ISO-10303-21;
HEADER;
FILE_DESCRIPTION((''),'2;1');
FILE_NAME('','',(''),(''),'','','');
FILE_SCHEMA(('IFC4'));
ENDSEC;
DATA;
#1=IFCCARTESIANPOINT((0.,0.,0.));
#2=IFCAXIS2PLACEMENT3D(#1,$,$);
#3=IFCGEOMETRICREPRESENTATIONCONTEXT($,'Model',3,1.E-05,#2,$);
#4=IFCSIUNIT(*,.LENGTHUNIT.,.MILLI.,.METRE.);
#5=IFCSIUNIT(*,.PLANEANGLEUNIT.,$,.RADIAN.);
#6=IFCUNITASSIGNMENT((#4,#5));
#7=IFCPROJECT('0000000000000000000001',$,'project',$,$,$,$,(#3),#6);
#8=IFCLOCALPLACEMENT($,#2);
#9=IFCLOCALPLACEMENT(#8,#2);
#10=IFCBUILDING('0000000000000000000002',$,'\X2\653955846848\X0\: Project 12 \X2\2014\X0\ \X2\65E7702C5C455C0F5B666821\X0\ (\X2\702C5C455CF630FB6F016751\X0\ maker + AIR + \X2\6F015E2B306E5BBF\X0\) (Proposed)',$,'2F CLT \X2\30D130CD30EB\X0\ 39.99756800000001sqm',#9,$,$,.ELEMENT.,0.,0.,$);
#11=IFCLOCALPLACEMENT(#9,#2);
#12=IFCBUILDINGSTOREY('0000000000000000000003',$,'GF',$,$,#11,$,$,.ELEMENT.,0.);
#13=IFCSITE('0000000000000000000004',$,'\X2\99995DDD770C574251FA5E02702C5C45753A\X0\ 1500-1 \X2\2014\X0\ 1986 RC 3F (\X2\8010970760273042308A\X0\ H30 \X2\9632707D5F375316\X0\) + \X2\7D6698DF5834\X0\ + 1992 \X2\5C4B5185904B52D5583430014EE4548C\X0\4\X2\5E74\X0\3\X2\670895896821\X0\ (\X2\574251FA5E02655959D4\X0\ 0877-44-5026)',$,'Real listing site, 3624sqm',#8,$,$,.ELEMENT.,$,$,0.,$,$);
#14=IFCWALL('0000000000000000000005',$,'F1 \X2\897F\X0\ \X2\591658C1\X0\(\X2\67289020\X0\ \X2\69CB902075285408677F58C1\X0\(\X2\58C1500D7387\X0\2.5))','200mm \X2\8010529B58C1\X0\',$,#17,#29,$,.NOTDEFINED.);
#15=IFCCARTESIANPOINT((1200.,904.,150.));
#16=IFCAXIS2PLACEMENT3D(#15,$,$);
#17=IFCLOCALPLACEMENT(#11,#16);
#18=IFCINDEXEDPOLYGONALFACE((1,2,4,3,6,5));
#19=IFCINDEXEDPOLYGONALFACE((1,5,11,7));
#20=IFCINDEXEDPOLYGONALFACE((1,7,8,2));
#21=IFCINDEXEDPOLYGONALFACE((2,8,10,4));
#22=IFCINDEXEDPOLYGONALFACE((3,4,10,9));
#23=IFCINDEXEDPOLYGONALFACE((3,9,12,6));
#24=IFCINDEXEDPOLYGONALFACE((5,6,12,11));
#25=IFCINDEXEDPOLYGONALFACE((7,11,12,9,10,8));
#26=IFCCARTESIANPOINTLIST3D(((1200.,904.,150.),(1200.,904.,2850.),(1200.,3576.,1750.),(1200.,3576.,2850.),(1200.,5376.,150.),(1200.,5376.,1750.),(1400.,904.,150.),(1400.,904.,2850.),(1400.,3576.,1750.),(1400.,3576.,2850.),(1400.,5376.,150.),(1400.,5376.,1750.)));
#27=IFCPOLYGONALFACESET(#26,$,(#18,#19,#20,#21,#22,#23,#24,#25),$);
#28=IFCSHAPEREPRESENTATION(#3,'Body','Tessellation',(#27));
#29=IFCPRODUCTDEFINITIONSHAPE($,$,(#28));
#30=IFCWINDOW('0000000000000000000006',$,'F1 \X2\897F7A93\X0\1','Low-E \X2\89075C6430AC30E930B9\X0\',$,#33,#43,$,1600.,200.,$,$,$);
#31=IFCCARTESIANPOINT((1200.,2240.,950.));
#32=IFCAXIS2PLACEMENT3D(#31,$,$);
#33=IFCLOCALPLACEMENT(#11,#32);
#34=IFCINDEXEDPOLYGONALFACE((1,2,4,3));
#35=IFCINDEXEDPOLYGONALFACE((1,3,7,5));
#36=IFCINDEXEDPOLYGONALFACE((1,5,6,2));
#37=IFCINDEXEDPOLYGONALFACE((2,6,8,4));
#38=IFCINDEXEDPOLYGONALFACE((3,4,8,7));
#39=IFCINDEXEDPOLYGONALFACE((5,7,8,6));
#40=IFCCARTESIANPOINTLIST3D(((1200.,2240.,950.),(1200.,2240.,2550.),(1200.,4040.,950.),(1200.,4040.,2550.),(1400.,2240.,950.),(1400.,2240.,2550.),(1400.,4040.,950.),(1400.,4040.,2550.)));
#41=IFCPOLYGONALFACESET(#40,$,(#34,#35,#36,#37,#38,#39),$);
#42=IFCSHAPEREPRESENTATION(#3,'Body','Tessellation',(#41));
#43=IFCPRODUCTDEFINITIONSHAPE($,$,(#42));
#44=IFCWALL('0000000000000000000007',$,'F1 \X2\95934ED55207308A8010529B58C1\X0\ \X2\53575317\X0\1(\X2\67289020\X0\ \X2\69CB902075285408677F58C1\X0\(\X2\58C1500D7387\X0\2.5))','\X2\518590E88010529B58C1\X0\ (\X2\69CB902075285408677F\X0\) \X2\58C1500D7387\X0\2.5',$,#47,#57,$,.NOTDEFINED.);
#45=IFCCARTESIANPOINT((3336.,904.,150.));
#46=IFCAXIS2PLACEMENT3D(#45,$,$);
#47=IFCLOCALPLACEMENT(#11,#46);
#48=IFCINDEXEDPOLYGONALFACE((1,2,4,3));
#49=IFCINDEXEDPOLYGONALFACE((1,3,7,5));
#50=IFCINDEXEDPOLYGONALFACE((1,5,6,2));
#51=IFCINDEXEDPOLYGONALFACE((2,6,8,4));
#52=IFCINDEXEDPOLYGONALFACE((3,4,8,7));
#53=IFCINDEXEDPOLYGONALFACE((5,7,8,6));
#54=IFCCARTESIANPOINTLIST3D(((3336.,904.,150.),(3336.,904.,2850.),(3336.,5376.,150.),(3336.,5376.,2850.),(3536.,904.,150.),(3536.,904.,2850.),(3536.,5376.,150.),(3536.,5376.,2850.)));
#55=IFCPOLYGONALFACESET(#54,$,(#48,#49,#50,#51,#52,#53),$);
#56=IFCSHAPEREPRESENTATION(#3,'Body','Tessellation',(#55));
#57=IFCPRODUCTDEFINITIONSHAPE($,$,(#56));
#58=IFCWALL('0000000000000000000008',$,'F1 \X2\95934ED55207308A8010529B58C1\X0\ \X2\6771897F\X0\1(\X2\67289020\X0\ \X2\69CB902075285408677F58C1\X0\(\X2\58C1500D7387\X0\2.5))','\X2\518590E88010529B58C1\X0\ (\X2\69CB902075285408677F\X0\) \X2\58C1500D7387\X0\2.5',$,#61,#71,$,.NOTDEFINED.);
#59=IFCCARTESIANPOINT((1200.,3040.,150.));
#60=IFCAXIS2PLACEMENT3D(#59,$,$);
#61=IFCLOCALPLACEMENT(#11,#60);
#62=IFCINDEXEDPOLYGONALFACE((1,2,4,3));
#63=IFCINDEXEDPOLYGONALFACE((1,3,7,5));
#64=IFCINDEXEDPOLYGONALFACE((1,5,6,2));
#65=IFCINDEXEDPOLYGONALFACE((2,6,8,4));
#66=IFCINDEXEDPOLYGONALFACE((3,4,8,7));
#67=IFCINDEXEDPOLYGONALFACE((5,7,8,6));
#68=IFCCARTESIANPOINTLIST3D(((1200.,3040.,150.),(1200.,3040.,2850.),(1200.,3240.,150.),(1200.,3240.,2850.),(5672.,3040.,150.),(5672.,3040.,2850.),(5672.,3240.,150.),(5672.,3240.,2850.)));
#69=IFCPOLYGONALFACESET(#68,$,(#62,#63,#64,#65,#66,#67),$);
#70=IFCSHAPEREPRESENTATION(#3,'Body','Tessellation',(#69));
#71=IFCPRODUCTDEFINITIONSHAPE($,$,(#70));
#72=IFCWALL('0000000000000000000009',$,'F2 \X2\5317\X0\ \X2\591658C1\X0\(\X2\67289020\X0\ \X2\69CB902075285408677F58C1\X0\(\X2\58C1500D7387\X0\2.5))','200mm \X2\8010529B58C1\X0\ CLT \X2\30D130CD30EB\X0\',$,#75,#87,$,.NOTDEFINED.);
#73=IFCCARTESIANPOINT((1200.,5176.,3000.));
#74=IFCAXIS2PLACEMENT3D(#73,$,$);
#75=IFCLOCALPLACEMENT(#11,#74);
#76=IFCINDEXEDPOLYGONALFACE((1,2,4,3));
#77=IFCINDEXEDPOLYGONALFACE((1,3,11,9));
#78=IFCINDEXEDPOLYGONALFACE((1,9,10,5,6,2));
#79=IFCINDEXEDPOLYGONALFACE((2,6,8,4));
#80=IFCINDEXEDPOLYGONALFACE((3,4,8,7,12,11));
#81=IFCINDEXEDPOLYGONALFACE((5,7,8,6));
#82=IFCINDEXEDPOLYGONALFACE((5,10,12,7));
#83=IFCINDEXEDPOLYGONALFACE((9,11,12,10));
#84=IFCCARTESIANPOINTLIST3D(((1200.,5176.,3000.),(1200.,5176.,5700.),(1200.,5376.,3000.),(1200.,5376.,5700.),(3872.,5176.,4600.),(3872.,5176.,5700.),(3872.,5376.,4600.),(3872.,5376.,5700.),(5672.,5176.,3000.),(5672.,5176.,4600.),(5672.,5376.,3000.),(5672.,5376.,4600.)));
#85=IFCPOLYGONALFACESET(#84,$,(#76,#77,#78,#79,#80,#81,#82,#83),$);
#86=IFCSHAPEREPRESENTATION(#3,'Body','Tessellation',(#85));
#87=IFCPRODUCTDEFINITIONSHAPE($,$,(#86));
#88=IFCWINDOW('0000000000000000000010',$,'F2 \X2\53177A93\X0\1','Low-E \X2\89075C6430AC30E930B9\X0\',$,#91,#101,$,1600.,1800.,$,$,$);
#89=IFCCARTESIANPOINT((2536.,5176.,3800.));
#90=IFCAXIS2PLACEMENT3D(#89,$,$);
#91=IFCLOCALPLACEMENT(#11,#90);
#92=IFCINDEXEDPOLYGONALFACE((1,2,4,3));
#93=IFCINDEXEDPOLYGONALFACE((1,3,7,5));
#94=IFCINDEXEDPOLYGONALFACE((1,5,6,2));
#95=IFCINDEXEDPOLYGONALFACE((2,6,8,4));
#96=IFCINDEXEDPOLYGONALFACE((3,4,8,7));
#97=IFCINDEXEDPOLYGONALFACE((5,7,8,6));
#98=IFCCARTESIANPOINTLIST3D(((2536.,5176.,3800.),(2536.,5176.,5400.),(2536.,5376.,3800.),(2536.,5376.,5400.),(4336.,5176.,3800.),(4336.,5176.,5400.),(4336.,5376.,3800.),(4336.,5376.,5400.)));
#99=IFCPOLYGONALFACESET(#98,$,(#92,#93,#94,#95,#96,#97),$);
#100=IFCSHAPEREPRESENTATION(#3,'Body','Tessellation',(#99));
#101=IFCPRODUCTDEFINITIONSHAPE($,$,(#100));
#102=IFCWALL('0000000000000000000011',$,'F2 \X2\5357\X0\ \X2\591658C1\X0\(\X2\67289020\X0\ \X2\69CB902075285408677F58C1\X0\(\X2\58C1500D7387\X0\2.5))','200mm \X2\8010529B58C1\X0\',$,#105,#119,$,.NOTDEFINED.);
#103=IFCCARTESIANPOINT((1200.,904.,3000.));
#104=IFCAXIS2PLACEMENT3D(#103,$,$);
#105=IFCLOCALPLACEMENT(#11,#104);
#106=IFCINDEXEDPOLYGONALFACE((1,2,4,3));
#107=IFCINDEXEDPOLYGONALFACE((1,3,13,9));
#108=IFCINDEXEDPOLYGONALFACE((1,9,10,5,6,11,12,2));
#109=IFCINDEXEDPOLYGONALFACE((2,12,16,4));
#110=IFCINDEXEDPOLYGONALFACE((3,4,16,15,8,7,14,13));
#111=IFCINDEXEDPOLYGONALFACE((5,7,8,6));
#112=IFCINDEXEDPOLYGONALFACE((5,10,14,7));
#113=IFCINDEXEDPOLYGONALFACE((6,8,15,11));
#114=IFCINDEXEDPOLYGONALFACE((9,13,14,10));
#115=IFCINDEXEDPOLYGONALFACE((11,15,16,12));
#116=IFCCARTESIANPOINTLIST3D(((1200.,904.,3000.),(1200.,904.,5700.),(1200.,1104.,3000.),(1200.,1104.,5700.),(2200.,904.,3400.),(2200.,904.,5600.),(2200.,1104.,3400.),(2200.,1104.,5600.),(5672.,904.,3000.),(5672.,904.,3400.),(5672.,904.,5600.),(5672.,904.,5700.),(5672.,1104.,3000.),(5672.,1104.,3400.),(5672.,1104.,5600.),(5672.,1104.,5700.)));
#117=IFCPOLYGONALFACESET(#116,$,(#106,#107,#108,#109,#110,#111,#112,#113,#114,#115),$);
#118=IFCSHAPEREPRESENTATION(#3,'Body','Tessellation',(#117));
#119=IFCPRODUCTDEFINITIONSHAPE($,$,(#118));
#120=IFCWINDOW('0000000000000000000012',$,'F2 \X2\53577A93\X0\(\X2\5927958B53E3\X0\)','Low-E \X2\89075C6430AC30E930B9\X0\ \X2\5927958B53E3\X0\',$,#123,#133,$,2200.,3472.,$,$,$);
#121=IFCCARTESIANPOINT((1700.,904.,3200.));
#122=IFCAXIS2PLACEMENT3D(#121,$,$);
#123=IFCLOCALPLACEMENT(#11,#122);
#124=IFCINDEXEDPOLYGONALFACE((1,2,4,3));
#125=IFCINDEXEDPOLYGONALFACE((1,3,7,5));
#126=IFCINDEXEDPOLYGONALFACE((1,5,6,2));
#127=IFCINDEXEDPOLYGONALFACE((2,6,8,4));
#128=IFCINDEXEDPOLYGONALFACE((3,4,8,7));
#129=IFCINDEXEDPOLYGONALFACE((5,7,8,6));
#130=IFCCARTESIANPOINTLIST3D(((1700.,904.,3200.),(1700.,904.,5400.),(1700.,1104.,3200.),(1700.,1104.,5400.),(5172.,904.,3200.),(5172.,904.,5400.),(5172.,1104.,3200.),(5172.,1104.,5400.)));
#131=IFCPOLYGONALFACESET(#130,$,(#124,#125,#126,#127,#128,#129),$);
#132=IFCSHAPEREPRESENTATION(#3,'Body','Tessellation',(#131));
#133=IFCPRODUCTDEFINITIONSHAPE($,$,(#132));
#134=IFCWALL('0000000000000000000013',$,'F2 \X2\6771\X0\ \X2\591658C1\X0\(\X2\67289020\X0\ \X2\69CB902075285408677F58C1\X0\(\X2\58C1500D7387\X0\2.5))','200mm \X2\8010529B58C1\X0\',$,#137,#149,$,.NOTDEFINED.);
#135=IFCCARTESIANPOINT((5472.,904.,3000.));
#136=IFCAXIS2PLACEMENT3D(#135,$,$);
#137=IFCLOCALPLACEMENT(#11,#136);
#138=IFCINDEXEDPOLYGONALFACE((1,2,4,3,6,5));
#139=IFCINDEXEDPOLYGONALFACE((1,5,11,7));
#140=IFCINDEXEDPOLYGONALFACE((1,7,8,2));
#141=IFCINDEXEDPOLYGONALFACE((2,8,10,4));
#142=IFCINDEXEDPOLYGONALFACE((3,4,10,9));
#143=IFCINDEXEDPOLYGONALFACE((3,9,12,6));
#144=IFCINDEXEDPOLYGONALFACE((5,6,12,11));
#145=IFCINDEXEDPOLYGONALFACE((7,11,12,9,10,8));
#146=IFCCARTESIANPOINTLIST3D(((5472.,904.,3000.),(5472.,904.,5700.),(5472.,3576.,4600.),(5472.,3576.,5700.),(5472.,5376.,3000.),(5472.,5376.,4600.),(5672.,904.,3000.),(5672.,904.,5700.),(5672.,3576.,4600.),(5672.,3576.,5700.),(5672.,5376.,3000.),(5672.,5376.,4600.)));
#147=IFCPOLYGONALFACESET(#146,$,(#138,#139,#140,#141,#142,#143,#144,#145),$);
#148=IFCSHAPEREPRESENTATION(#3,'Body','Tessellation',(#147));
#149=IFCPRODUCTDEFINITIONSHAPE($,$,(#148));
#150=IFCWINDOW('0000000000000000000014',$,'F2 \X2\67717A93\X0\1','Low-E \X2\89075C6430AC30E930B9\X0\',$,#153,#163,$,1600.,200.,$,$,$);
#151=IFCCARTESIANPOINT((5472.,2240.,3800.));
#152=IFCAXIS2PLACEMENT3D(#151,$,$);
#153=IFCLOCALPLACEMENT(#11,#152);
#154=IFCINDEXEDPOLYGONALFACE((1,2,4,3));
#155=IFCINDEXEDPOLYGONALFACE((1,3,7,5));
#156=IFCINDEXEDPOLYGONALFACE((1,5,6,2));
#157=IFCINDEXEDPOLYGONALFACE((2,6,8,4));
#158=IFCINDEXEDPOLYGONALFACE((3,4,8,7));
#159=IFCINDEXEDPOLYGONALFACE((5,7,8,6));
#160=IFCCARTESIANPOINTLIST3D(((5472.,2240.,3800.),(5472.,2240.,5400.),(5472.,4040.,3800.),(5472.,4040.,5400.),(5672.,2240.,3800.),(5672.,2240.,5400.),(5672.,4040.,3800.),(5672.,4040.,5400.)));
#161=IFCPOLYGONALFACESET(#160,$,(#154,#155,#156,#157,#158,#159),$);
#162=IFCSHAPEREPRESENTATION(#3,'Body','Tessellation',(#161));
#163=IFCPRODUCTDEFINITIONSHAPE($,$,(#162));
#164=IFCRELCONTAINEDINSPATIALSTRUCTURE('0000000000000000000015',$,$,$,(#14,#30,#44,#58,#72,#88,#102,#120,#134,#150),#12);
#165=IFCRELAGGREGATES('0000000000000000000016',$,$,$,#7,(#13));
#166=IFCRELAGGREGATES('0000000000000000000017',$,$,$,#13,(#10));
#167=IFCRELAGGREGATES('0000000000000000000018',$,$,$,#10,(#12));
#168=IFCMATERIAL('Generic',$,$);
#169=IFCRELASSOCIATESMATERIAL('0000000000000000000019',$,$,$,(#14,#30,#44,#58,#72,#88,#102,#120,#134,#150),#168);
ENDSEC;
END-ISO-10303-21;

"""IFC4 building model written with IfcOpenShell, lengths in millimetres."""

from ifc_helpers import new_model, si_unit, frame, frame_2d, origin, place, context, project, spatial, rectangle, extrude, material, element, fill, save


model = new_model("IFC4")

# Units and contexts
model_context = context("Model", 3, precision=1e-05, world=origin())
ifc_project = project(units=[si_unit("LENGTHUNIT", "METRE", prefix="MILLI"), si_unit("PLANEANGLEUNIT", "RADIAN")], contexts=[model_context])

# Site, building, storey
site_placement = place(None, origin())
site = spatial("IfcSite", under=ifc_project, at=site_placement, Name="香川県坂出市瀬居町 1500-1 — 1986 RC 3F (耐震性あり H30 防災強化) + 給食場 + 1992 屋内運動場、令和4年3月閉校 (坂出市教委 0877-44-5026)", ObjectType="Real listing site, 3624sqm", CompositionType="ELEMENT", RefElevation=0.0)
building_placement = place(site_placement, origin())
building = spatial("IfcBuilding", under=site, at=building_placement, Name="改善案: Project 12 — 旧瀬居小学校 (瀬居島・漁村 maker + AIR + 漁師の宿) (Proposed)", ObjectType="2F CLT パネル 39.99756800000001sqm", CompositionType="ELEMENT", ElevationOfRefHeight=0.0, ElevationOfTerrain=0.0)
storey_placement = place(building_placement, origin())
storey = spatial("IfcBuildingStorey", under=building, at=storey_placement, Name="GF", CompositionType="ELEMENT", Elevation=0.0)

# Shared definitions
ifc_material_1 = material(Name="Generic")

# Wall, opening, window
wall_1_placement = place(storey_placement, frame((1200.0, 904.0, 150.0)))
wall_1 = element("IfcWall", 1, at=wall_1_placement, inside=storey, material=ifc_material_1, Name="F1 西 外壁(木造 構造用合板壁(壁倍率2.5))", Description="200mm 耐力壁", PredefinedType="NOTDEFINED", context=model_context, shape_type="SweptSolid", body=[
    extrude(rectangle(XDim=200.0, YDim=4472.0, at=frame_2d((100.0, 2236.0))), frame((1200.0, 904.0, 150.0)), (0.0, 0.0, 1.0), 2700.0),
])
opening_1_placement = place(storey_placement, frame((1200.0, 2240.0, 950.0)))
opening_1 = element("IfcOpeningElement", 2, at=opening_1_placement, cuts=wall_1, PredefinedType="NOTDEFINED", context=model_context, shape_type="SweptSolid", body=[
    extrude(rectangle(XDim=200.0, YDim=1800.0, at=frame_2d((100.0, 900.0))), frame((1200.0, 2240.0, 950.0)), (0.0, 0.0, 1.0), 1600.0),
])
window_1_placement = place(storey_placement, frame((1200.0, 2240.0, 950.0)))
window_1 = element("IfcWindow", 3, at=window_1_placement, inside=storey, material=ifc_material_1, Name="F1 西窓1", Description="Low-E 複層ガラス", OverallHeight=1600.0, OverallWidth=200.0, context=model_context, shape_type="SweptSolid", body=[
    extrude(rectangle(XDim=200.0, YDim=1800.0, at=frame_2d((100.0, 900.0))), frame((1200.0, 2240.0, 950.0)), (0.0, 0.0, 1.0), 1600.0),
])
fill(opening_1, window_1)

# Walls
wall_2_placement = place(storey_placement, frame((3336.0, 904.0, 150.0)))
element("IfcWall", 4, at=wall_2_placement, inside=storey, material=ifc_material_1, Name="F1 間仕切り耐力壁 南北1(木造 構造用合板壁(壁倍率2.5))", Description="内部耐力壁 (構造用合板) 壁倍率2.5", PredefinedType="NOTDEFINED", context=model_context, shape_type="SweptSolid", body=[
    extrude(rectangle(XDim=200.0, YDim=4472.0, at=frame_2d((100.0, 2236.0))), frame((3336.0, 904.0, 150.0)), (0.0, 0.0, 1.0), 2700.0),
])
wall_3_placement = place(storey_placement, frame((1200.0, 3040.0, 150.0)))
element("IfcWall", 5, at=wall_3_placement, inside=storey, material=ifc_material_1, Name="F1 間仕切り耐力壁 東西1(木造 構造用合板壁(壁倍率2.5))", Description="内部耐力壁 (構造用合板) 壁倍率2.5", PredefinedType="NOTDEFINED", context=model_context, shape_type="SweptSolid", body=[
    extrude(rectangle(XDim=4472.0, YDim=200.0, at=frame_2d((2236.0, 100.0))), frame((1200.0, 3040.0, 150.0)), (0.0, 0.0, 1.0), 2700.0),
])

# Walls, openings, windows
wall_4_placement = place(storey_placement, frame((1200.0, 5176.0, 3000.0)))
wall_4 = element("IfcWall", 6, at=wall_4_placement, inside=storey, material=ifc_material_1, Name="F2 北 外壁(木造 構造用合板壁(壁倍率2.5))", Description="200mm 耐力壁 CLT パネル", PredefinedType="NOTDEFINED", context=model_context, shape_type="SweptSolid", body=[
    extrude(rectangle(XDim=4472.0, YDim=200.0, at=frame_2d((2236.0, 100.0))), frame((1200.0, 5176.0, 3000.0)), (0.0, 0.0, 1.0), 2700.0),
])
opening_2_placement = place(storey_placement, frame((2536.0, 5176.0, 3800.0)))
opening_2 = element("IfcOpeningElement", 7, at=opening_2_placement, cuts=wall_4, PredefinedType="NOTDEFINED", context=model_context, shape_type="SweptSolid", body=[
    extrude(rectangle(XDim=1800.0, YDim=200.0, at=frame_2d((900.0, 100.0))), frame((2536.0, 5176.0, 3800.0)), (0.0, 0.0, 1.0), 1600.0),
])
window_2_placement = place(storey_placement, frame((2536.0, 5176.0, 3800.0)))
window_2 = element("IfcWindow", 8, at=window_2_placement, inside=storey, material=ifc_material_1, Name="F2 北窓1", Description="Low-E 複層ガラス", OverallHeight=1600.0, OverallWidth=1800.0, context=model_context, shape_type="SweptSolid", body=[
    extrude(rectangle(XDim=1800.0, YDim=200.0, at=frame_2d((900.0, 100.0))), frame((2536.0, 5176.0, 3800.0)), (0.0, 0.0, 1.0), 1600.0),
])
fill(opening_2, window_2)
wall_5_placement = place(storey_placement, frame((1200.0, 904.0, 3000.0)))
wall_5 = element("IfcWall", 9, at=wall_5_placement, inside=storey, material=ifc_material_1, Name="F2 南 外壁(木造 構造用合板壁(壁倍率2.5))", Description="200mm 耐力壁", PredefinedType="NOTDEFINED", context=model_context, shape_type="SweptSolid", body=[
    extrude(rectangle(XDim=4472.0, YDim=200.0, at=frame_2d((2236.0, 100.0))), frame((1200.0, 904.0, 3000.0)), (0.0, 0.0, 1.0), 2700.0),
])
opening_3_placement = place(storey_placement, frame((1700.0, 904.0, 3200.0)))
opening_3 = element("IfcOpeningElement", 10, at=opening_3_placement, cuts=wall_5, PredefinedType="NOTDEFINED", context=model_context, shape_type="SweptSolid", body=[
    extrude(rectangle(XDim=3472.0, YDim=200.0, at=frame_2d((1736.0, 100.0))), frame((1700.0, 904.0, 3200.0)), (0.0, 0.0, 1.0), 2200.0),
])
window_3_placement = place(storey_placement, frame((1700.0, 904.0, 3200.0)))
window_3 = element("IfcWindow", 11, at=window_3_placement, inside=storey, material=ifc_material_1, Name="F2 南窓(大開口)", Description="Low-E 複層ガラス 大開口", OverallHeight=2200.0, OverallWidth=3472.0, context=model_context, shape_type="SweptSolid", body=[
    extrude(rectangle(XDim=3472.0, YDim=200.0, at=frame_2d((1736.0, 100.0))), frame((1700.0, 904.0, 3200.0)), (0.0, 0.0, 1.0), 2200.0),
])
fill(opening_3, window_3)
wall_6_placement = place(storey_placement, frame((5472.0, 904.0, 3000.0)))
wall_6 = element("IfcWall", 12, at=wall_6_placement, inside=storey, material=ifc_material_1, Name="F2 東 外壁(木造 構造用合板壁(壁倍率2.5))", Description="200mm 耐力壁", PredefinedType="NOTDEFINED", context=model_context, shape_type="SweptSolid", body=[
    extrude(rectangle(XDim=200.0, YDim=4472.0, at=frame_2d((100.0, 2236.0))), frame((5472.0, 904.0, 3000.0)), (0.0, 0.0, 1.0), 2700.0),
])
opening_4_placement = place(storey_placement, frame((5472.0, 2240.0, 3800.0)))
opening_4 = element("IfcOpeningElement", 13, at=opening_4_placement, cuts=wall_6, PredefinedType="NOTDEFINED", context=model_context, shape_type="SweptSolid", body=[
    extrude(rectangle(XDim=200.0, YDim=1800.0, at=frame_2d((100.0, 900.0))), frame((5472.0, 2240.0, 3800.0)), (0.0, 0.0, 1.0), 1600.0),
])
window_4_placement = place(storey_placement, frame((5472.0, 2240.0, 3800.0)))
window_4 = element("IfcWindow", 14, at=window_4_placement, inside=storey, material=ifc_material_1, Name="F2 東窓1", Description="Low-E 複層ガラス", OverallHeight=1600.0, OverallWidth=200.0, context=model_context, shape_type="SweptSolid", body=[
    extrude(rectangle(XDim=200.0, YDim=1800.0, at=frame_2d((100.0, 900.0))), frame((5472.0, 2240.0, 3800.0)), (0.0, 0.0, 1.0), 1600.0),
])
fill(opening_4, window_4)

save(model, "model.ifc")
